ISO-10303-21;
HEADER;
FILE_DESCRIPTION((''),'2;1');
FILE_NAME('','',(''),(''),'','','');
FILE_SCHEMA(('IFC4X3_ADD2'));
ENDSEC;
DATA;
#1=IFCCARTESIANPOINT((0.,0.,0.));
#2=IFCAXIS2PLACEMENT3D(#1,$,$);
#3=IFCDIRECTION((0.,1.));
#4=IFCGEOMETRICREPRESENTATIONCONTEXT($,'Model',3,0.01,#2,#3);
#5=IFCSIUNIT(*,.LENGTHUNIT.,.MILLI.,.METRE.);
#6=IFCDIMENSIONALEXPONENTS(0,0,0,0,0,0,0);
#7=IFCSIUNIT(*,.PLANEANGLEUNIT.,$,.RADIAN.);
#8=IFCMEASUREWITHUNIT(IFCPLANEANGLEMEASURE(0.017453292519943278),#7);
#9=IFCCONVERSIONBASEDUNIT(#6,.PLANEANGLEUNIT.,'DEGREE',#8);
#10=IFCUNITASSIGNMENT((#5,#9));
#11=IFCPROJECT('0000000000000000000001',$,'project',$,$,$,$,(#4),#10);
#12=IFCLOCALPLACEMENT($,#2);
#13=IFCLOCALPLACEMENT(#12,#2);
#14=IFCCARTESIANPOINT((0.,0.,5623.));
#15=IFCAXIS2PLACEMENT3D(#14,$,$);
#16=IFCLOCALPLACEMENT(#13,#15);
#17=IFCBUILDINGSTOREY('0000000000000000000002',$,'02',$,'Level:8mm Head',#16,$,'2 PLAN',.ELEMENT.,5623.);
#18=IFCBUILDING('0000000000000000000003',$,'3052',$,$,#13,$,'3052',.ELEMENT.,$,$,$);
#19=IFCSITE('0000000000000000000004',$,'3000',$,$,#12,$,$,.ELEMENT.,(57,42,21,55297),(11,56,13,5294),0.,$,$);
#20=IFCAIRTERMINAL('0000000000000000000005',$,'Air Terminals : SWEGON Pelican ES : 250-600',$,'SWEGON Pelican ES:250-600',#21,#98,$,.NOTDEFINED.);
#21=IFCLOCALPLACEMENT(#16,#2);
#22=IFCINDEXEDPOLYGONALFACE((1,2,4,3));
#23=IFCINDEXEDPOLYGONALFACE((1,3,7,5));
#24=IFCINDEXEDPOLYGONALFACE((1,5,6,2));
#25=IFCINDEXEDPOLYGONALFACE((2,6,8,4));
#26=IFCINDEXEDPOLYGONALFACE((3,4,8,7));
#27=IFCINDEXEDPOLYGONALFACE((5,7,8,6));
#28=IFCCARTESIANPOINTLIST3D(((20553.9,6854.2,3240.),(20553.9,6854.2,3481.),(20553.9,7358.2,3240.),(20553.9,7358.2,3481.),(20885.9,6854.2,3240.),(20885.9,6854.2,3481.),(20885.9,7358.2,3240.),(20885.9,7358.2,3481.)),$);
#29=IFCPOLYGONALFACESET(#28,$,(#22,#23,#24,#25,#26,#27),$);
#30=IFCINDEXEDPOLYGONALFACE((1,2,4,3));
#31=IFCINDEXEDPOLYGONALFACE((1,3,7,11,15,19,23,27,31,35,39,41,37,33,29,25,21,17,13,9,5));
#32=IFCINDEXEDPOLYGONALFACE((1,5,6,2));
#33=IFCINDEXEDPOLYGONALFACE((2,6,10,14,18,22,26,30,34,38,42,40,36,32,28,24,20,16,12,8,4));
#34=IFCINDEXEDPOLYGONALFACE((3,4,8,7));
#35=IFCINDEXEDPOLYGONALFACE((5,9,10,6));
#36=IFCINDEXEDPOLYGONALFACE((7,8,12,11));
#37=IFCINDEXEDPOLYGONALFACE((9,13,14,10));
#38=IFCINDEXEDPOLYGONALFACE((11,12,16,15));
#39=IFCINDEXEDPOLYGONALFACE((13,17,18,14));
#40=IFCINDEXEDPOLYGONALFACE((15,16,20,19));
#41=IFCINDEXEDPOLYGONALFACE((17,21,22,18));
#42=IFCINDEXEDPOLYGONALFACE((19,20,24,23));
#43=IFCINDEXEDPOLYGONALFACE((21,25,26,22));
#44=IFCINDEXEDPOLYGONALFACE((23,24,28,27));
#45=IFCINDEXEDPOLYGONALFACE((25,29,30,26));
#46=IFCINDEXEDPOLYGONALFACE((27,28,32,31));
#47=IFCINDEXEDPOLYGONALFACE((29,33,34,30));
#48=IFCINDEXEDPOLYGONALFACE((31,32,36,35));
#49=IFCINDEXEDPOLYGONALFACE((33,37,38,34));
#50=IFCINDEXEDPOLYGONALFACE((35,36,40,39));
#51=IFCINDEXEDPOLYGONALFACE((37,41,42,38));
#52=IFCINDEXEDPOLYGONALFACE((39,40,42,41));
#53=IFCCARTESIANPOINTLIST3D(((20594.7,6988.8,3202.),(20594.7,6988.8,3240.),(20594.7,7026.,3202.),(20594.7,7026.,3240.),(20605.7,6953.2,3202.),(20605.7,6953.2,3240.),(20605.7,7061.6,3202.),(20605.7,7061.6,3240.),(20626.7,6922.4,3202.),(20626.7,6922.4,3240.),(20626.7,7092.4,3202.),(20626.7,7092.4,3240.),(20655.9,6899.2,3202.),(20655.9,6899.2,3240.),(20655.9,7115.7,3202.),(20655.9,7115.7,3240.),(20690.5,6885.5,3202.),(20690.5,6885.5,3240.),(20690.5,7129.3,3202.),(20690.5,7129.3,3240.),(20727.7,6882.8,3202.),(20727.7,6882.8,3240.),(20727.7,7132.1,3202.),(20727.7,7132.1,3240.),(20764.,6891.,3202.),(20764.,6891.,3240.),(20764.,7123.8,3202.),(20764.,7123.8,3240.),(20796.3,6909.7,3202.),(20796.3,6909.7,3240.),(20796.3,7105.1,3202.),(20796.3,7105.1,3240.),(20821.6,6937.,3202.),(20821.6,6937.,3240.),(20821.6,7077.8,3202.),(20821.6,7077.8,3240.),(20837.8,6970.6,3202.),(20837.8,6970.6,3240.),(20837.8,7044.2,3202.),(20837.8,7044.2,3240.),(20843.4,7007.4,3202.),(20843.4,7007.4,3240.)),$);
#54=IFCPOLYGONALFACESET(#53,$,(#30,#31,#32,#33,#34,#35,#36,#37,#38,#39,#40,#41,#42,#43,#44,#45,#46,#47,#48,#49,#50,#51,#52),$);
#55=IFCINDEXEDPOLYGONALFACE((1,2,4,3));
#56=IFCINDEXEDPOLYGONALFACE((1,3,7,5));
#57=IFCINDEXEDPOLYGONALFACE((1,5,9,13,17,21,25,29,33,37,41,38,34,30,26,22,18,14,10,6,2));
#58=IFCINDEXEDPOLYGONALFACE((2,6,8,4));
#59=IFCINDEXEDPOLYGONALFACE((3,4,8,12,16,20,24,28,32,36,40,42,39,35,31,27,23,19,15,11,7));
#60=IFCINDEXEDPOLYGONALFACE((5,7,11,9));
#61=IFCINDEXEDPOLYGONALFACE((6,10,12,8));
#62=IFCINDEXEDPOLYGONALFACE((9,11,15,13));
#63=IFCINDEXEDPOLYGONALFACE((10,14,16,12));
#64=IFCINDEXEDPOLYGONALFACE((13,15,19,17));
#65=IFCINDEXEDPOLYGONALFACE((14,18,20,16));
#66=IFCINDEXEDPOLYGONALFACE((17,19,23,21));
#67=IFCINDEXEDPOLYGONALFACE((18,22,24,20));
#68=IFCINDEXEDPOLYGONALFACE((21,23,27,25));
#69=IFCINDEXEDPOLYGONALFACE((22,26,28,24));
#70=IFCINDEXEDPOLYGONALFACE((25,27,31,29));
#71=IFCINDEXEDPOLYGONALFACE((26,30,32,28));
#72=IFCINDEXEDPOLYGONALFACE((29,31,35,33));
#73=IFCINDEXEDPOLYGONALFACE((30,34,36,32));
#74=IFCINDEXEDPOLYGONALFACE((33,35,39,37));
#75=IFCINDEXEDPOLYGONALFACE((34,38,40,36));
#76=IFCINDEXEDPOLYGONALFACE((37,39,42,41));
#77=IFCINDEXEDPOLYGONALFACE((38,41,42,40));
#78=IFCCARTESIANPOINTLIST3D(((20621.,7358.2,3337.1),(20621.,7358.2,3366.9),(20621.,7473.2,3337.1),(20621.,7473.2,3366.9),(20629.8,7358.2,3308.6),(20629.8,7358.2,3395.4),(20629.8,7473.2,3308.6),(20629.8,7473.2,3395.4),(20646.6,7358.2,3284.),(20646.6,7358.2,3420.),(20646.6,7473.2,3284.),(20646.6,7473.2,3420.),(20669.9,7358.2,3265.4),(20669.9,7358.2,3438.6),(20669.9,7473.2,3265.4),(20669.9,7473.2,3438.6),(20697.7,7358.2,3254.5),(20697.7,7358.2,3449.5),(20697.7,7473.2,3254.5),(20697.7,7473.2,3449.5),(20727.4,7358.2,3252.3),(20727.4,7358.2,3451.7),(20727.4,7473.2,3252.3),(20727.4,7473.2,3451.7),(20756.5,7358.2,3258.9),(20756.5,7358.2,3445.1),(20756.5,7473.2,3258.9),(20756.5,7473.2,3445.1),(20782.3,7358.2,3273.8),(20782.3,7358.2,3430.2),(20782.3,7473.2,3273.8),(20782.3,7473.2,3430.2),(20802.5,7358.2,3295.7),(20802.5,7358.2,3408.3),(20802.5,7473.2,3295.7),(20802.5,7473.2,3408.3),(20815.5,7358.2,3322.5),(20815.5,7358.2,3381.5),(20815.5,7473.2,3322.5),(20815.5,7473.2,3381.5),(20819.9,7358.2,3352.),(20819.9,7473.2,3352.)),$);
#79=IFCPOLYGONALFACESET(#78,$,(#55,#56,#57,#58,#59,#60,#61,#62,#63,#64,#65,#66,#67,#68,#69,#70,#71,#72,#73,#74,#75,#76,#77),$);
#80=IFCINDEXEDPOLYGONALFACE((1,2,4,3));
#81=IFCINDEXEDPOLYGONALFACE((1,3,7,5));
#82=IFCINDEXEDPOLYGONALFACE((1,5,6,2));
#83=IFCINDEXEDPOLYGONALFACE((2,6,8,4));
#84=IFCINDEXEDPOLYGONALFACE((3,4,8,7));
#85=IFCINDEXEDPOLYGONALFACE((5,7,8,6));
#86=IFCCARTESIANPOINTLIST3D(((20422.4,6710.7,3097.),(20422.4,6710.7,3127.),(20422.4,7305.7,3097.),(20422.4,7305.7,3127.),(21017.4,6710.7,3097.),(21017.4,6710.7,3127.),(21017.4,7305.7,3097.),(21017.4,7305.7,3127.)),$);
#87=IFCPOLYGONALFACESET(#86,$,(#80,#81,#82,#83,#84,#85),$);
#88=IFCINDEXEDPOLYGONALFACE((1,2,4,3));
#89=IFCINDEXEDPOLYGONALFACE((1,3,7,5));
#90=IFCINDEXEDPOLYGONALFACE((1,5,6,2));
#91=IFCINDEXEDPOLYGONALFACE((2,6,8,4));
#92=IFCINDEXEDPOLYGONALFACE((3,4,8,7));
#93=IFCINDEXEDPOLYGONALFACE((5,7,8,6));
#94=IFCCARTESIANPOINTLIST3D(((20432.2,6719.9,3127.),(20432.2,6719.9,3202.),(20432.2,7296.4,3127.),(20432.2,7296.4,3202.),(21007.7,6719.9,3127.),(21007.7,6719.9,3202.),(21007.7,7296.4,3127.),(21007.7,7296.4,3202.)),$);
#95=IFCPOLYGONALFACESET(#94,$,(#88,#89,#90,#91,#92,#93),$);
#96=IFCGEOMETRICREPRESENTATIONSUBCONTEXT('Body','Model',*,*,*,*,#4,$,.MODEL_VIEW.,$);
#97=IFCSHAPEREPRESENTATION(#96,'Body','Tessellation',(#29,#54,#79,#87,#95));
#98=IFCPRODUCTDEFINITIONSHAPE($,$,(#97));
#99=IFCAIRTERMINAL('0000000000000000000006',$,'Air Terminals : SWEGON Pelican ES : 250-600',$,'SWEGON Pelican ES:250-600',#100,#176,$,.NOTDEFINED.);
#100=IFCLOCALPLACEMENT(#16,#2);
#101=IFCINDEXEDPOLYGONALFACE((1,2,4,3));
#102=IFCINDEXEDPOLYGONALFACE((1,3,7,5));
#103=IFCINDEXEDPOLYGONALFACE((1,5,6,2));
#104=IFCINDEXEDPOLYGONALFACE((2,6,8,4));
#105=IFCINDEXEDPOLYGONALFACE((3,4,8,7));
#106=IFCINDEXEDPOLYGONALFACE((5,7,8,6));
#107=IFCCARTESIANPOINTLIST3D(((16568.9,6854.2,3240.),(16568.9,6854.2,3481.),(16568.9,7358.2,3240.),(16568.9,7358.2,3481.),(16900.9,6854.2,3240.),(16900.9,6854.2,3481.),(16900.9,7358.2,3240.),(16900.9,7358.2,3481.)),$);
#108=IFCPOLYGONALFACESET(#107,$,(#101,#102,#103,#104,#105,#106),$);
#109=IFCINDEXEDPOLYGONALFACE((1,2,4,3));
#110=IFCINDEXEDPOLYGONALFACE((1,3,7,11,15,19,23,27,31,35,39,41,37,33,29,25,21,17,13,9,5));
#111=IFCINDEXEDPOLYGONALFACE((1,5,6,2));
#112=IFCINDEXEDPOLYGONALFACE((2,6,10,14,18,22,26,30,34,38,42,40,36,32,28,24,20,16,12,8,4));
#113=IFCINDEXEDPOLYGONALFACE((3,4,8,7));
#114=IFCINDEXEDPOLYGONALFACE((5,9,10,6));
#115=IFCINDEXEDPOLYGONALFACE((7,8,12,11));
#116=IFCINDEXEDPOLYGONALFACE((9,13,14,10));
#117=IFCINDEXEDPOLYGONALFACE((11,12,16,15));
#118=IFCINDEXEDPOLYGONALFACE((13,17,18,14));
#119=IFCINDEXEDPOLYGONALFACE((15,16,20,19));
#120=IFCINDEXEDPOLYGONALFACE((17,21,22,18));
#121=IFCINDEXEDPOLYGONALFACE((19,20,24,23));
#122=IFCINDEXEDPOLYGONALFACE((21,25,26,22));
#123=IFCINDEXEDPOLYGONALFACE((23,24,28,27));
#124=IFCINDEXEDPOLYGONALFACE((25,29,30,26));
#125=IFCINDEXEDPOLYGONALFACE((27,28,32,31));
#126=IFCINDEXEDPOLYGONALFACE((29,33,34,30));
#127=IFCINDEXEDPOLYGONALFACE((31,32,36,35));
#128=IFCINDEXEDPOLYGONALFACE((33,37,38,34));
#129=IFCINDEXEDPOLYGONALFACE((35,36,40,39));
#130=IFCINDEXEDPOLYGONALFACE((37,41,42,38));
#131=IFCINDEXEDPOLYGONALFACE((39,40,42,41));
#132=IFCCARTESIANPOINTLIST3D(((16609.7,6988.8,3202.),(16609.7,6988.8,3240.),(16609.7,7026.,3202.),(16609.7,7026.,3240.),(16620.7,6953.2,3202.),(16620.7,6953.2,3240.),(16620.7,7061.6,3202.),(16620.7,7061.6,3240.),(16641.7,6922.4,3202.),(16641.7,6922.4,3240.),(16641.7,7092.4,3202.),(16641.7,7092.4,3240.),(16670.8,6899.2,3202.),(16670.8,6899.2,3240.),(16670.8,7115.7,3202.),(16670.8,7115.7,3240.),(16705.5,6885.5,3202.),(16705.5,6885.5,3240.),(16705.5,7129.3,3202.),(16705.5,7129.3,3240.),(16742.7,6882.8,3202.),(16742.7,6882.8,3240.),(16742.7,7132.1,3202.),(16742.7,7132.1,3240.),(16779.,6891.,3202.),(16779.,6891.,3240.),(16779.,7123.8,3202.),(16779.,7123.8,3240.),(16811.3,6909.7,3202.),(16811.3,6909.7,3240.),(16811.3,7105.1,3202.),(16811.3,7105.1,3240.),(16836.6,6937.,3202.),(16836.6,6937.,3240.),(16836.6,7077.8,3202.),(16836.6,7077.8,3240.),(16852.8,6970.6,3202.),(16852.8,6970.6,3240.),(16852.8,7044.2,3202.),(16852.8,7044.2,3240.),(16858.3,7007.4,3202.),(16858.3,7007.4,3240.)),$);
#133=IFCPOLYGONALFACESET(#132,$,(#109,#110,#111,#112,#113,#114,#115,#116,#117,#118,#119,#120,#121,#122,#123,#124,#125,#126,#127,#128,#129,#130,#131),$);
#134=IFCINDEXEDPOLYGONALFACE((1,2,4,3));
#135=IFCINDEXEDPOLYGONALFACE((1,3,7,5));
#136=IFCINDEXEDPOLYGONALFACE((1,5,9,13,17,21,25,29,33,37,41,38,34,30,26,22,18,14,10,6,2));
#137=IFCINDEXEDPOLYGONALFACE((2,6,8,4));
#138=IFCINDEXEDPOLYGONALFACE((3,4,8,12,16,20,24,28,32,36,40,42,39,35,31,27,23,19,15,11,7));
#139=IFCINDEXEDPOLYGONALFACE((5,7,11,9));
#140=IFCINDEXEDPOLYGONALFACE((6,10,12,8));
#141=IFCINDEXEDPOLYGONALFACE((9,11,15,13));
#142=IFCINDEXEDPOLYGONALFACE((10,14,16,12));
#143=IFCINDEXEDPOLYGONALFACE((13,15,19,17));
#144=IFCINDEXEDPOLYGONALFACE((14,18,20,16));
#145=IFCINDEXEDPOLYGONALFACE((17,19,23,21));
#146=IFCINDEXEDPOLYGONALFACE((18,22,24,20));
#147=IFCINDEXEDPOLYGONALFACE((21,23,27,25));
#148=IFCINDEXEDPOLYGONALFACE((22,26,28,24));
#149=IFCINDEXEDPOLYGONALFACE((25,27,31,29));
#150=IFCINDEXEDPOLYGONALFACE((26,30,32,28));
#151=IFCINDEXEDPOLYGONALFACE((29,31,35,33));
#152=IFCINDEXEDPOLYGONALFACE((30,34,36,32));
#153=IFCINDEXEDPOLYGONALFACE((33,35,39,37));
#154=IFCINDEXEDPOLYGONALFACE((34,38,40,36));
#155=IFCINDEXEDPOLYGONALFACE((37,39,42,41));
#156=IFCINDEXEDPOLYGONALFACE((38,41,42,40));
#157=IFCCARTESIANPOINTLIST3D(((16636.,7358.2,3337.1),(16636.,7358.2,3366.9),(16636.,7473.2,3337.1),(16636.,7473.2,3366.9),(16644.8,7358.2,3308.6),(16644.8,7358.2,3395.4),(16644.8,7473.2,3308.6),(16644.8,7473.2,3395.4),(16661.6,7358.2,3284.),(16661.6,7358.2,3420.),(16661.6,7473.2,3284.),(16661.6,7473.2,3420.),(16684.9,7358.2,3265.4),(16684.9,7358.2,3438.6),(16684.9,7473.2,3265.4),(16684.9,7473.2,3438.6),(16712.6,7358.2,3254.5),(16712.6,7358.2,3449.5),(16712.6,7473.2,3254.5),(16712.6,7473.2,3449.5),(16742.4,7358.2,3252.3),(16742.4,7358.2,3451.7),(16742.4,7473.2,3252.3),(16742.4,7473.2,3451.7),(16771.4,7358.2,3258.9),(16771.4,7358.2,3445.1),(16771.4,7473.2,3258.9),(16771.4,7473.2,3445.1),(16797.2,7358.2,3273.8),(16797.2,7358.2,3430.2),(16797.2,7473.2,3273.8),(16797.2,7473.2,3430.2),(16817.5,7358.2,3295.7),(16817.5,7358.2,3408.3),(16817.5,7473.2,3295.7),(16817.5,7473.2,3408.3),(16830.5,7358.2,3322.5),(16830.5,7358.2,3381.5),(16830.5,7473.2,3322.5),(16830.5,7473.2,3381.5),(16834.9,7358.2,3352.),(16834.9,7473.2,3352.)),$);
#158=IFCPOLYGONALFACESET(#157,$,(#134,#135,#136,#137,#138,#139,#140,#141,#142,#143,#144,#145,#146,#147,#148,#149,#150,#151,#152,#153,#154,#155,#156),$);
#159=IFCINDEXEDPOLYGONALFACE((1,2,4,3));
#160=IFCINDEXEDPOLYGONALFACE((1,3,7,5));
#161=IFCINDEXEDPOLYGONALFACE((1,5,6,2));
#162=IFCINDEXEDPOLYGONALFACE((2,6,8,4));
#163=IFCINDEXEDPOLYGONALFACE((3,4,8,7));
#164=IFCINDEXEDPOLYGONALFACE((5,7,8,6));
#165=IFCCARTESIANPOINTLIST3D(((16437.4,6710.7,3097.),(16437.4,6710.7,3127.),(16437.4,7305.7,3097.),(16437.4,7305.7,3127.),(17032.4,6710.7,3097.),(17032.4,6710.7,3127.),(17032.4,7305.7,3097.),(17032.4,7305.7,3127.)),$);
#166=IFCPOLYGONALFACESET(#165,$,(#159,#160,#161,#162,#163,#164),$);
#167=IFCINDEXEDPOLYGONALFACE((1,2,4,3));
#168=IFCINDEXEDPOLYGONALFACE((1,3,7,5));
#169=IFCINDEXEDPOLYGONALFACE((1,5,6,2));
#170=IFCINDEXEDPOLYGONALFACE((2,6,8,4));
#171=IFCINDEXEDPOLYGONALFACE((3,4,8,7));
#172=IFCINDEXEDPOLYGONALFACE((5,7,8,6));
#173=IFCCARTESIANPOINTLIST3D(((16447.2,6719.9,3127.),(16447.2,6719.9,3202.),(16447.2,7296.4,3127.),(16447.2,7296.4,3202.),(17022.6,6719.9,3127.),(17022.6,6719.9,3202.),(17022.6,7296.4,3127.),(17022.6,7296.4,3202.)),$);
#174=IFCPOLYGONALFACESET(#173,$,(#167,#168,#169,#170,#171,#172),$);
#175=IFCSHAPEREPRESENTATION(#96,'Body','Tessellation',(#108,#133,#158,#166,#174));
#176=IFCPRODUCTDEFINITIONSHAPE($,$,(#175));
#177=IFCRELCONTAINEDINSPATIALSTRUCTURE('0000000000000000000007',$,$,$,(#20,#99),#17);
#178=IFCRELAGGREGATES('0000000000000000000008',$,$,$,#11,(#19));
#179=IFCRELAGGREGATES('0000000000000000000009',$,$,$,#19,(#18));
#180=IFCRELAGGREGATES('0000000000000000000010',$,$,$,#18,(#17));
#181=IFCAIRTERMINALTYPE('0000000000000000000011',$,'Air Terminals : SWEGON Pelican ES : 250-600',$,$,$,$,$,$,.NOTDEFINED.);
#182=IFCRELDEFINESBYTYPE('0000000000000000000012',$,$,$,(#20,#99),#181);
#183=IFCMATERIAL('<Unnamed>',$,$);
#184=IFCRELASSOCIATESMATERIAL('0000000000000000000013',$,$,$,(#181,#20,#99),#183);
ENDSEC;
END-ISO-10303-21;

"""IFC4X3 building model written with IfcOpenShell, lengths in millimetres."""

from ifc_helpers import new_model, entity, si_unit, converted_unit, direction, frame, frame_2d, origin, origin_2d_with_axis, place, context, subcontext, project, spatial, rectangle, circle, extrude, source, transform, mapped, material, type_object, type_shapes, element, save


model = new_model("IFC4X3")

# Units and contexts
model_context = context("Model", 3, precision=0.01, world=origin(), true_north=direction((0.0, 1.0)))
body_context = subcontext(model_context, "Body", "Model", "MODEL_VIEW")
ifc_project = project(units=[si_unit("LENGTHUNIT", "METRE", prefix="MILLI"), converted_unit("PLANEANGLEUNIT", "DEGREE", entity("IfcPlaneAngleMeasure", 0.017453292519943278), si_unit("PLANEANGLEUNIT", "RADIAN"), dimensions=[0, 0, 0, 0, 0, 0, 0])], contexts=[model_context])

# Site, building, storey
site_placement = place(None, origin())
site = spatial("IfcSite", under=ifc_project, at=site_placement, Name="3000", CompositionType="ELEMENT", RefLatitude=(57, 42, 21, 55297), RefLongitude=(11, 56, 13, 5294), RefElevation=0.0)
building_placement = place(site_placement, origin())
building = spatial("IfcBuilding", under=site, at=building_placement, Name="3052", LongName="3052", CompositionType="ELEMENT")
storey_placement = place(building_placement, frame((0.0, 0.0, 5623.0)))
storey = spatial("IfcBuildingStorey", under=building, at=storey_placement, Name="02", ObjectType="Level:8mm Head", LongName="2 PLAN", CompositionType="ELEMENT", Elevation=5623.0)

# Shared definitions
ifc_material_1 = material(Name="<Unnamed>")

# Air terminals
air_terminal_type_1 = type_object("IfcAirTerminalType", Name="Air Terminals : SWEGON Pelican ES : 250-600", PredefinedType="NOTDEFINED", material=ifc_material_1)
shared_shape_1 = source(origin(), body_context, "Body", "SweptSolid", [
    extrude(rectangle(XDim=504.0, YDim=332.0, at=origin_2d_with_axis()), frame((0.0, -98.0, -354.0), z_axis=(0.0, 0.0, 1.0), x_axis=(0.0, 1.0, 0.0)), (0.0, 0.0, 1.0), 241.0),
    extrude(circle(Radius=125.0, at=frame_2d((0.0, 0.0), x_axis=(1.0, 0.0))), frame((-1.6, 0.8, -113.0)), (0.0, 0.0, 1.0), 38.0),
    extrude(circle(Radius=100.0, at=frame_2d((0.0, 0.0), x_axis=(1.0, 0.0))), frame((0.0, -465.0, -225.0), z_axis=(0.0, 1.0, 0.0), x_axis=(1.0, 0.0, 0.0)), (0.0, 0.0, 1.0), 115.0),
    extrude(rectangle(XDim=595.0, YDim=595.0, at=frame_2d((0.0, 0.0), x_axis=(1.0, 0.0))), frame((0.0, 0.0, 0.0), z_axis=(0.0, 0.0, 1.0), x_axis=(0.0, 1.0, 0.0)), (0.0, 0.0, 1.0), 30.0),
    extrude(rectangle(XDim=576.5, YDim=575.5, at=origin_2d_with_axis()), frame((0.0, 0.0, -75.0), z_axis=(0.0, 0.0, 1.0), x_axis=(0.0, 1.0, 0.0)), (0.0, 0.0, 1.0), 75.0),
])
type_shapes(air_terminal_type_1, [shared_shape_1])
for number, where, z_axis, x_axis, name in (
    (1, (20719.9, 7008.2, 3127.0), (0.0, 0.0, -1.0), (1.0, 0.0, 0.0), "Air Terminals : SWEGON Pelican ES : 250-600"),
    (2, (16734.9, 7008.2, 3127.0), (0.0, 0.0, -1.0), (1.0, 0.0, 0.0), "Air Terminals : SWEGON Pelican ES : 250-600"),
):
    element("IfcAirTerminal", number, at=place(storey_placement, frame(where, z_axis=z_axis, x_axis=x_axis)), inside=storey, type_object=air_terminal_type_1, material=ifc_material_1, Name=name, ObjectType="SWEGON Pelican ES:250-600", PredefinedType="NOTDEFINED", context=body_context, shape_type="MappedRepresentation", body=[
        mapped(shared_shape_1, transform((0.0, 0.0, 0.0), scale=1.0)),
    ])

save(model, "model.ifc")
